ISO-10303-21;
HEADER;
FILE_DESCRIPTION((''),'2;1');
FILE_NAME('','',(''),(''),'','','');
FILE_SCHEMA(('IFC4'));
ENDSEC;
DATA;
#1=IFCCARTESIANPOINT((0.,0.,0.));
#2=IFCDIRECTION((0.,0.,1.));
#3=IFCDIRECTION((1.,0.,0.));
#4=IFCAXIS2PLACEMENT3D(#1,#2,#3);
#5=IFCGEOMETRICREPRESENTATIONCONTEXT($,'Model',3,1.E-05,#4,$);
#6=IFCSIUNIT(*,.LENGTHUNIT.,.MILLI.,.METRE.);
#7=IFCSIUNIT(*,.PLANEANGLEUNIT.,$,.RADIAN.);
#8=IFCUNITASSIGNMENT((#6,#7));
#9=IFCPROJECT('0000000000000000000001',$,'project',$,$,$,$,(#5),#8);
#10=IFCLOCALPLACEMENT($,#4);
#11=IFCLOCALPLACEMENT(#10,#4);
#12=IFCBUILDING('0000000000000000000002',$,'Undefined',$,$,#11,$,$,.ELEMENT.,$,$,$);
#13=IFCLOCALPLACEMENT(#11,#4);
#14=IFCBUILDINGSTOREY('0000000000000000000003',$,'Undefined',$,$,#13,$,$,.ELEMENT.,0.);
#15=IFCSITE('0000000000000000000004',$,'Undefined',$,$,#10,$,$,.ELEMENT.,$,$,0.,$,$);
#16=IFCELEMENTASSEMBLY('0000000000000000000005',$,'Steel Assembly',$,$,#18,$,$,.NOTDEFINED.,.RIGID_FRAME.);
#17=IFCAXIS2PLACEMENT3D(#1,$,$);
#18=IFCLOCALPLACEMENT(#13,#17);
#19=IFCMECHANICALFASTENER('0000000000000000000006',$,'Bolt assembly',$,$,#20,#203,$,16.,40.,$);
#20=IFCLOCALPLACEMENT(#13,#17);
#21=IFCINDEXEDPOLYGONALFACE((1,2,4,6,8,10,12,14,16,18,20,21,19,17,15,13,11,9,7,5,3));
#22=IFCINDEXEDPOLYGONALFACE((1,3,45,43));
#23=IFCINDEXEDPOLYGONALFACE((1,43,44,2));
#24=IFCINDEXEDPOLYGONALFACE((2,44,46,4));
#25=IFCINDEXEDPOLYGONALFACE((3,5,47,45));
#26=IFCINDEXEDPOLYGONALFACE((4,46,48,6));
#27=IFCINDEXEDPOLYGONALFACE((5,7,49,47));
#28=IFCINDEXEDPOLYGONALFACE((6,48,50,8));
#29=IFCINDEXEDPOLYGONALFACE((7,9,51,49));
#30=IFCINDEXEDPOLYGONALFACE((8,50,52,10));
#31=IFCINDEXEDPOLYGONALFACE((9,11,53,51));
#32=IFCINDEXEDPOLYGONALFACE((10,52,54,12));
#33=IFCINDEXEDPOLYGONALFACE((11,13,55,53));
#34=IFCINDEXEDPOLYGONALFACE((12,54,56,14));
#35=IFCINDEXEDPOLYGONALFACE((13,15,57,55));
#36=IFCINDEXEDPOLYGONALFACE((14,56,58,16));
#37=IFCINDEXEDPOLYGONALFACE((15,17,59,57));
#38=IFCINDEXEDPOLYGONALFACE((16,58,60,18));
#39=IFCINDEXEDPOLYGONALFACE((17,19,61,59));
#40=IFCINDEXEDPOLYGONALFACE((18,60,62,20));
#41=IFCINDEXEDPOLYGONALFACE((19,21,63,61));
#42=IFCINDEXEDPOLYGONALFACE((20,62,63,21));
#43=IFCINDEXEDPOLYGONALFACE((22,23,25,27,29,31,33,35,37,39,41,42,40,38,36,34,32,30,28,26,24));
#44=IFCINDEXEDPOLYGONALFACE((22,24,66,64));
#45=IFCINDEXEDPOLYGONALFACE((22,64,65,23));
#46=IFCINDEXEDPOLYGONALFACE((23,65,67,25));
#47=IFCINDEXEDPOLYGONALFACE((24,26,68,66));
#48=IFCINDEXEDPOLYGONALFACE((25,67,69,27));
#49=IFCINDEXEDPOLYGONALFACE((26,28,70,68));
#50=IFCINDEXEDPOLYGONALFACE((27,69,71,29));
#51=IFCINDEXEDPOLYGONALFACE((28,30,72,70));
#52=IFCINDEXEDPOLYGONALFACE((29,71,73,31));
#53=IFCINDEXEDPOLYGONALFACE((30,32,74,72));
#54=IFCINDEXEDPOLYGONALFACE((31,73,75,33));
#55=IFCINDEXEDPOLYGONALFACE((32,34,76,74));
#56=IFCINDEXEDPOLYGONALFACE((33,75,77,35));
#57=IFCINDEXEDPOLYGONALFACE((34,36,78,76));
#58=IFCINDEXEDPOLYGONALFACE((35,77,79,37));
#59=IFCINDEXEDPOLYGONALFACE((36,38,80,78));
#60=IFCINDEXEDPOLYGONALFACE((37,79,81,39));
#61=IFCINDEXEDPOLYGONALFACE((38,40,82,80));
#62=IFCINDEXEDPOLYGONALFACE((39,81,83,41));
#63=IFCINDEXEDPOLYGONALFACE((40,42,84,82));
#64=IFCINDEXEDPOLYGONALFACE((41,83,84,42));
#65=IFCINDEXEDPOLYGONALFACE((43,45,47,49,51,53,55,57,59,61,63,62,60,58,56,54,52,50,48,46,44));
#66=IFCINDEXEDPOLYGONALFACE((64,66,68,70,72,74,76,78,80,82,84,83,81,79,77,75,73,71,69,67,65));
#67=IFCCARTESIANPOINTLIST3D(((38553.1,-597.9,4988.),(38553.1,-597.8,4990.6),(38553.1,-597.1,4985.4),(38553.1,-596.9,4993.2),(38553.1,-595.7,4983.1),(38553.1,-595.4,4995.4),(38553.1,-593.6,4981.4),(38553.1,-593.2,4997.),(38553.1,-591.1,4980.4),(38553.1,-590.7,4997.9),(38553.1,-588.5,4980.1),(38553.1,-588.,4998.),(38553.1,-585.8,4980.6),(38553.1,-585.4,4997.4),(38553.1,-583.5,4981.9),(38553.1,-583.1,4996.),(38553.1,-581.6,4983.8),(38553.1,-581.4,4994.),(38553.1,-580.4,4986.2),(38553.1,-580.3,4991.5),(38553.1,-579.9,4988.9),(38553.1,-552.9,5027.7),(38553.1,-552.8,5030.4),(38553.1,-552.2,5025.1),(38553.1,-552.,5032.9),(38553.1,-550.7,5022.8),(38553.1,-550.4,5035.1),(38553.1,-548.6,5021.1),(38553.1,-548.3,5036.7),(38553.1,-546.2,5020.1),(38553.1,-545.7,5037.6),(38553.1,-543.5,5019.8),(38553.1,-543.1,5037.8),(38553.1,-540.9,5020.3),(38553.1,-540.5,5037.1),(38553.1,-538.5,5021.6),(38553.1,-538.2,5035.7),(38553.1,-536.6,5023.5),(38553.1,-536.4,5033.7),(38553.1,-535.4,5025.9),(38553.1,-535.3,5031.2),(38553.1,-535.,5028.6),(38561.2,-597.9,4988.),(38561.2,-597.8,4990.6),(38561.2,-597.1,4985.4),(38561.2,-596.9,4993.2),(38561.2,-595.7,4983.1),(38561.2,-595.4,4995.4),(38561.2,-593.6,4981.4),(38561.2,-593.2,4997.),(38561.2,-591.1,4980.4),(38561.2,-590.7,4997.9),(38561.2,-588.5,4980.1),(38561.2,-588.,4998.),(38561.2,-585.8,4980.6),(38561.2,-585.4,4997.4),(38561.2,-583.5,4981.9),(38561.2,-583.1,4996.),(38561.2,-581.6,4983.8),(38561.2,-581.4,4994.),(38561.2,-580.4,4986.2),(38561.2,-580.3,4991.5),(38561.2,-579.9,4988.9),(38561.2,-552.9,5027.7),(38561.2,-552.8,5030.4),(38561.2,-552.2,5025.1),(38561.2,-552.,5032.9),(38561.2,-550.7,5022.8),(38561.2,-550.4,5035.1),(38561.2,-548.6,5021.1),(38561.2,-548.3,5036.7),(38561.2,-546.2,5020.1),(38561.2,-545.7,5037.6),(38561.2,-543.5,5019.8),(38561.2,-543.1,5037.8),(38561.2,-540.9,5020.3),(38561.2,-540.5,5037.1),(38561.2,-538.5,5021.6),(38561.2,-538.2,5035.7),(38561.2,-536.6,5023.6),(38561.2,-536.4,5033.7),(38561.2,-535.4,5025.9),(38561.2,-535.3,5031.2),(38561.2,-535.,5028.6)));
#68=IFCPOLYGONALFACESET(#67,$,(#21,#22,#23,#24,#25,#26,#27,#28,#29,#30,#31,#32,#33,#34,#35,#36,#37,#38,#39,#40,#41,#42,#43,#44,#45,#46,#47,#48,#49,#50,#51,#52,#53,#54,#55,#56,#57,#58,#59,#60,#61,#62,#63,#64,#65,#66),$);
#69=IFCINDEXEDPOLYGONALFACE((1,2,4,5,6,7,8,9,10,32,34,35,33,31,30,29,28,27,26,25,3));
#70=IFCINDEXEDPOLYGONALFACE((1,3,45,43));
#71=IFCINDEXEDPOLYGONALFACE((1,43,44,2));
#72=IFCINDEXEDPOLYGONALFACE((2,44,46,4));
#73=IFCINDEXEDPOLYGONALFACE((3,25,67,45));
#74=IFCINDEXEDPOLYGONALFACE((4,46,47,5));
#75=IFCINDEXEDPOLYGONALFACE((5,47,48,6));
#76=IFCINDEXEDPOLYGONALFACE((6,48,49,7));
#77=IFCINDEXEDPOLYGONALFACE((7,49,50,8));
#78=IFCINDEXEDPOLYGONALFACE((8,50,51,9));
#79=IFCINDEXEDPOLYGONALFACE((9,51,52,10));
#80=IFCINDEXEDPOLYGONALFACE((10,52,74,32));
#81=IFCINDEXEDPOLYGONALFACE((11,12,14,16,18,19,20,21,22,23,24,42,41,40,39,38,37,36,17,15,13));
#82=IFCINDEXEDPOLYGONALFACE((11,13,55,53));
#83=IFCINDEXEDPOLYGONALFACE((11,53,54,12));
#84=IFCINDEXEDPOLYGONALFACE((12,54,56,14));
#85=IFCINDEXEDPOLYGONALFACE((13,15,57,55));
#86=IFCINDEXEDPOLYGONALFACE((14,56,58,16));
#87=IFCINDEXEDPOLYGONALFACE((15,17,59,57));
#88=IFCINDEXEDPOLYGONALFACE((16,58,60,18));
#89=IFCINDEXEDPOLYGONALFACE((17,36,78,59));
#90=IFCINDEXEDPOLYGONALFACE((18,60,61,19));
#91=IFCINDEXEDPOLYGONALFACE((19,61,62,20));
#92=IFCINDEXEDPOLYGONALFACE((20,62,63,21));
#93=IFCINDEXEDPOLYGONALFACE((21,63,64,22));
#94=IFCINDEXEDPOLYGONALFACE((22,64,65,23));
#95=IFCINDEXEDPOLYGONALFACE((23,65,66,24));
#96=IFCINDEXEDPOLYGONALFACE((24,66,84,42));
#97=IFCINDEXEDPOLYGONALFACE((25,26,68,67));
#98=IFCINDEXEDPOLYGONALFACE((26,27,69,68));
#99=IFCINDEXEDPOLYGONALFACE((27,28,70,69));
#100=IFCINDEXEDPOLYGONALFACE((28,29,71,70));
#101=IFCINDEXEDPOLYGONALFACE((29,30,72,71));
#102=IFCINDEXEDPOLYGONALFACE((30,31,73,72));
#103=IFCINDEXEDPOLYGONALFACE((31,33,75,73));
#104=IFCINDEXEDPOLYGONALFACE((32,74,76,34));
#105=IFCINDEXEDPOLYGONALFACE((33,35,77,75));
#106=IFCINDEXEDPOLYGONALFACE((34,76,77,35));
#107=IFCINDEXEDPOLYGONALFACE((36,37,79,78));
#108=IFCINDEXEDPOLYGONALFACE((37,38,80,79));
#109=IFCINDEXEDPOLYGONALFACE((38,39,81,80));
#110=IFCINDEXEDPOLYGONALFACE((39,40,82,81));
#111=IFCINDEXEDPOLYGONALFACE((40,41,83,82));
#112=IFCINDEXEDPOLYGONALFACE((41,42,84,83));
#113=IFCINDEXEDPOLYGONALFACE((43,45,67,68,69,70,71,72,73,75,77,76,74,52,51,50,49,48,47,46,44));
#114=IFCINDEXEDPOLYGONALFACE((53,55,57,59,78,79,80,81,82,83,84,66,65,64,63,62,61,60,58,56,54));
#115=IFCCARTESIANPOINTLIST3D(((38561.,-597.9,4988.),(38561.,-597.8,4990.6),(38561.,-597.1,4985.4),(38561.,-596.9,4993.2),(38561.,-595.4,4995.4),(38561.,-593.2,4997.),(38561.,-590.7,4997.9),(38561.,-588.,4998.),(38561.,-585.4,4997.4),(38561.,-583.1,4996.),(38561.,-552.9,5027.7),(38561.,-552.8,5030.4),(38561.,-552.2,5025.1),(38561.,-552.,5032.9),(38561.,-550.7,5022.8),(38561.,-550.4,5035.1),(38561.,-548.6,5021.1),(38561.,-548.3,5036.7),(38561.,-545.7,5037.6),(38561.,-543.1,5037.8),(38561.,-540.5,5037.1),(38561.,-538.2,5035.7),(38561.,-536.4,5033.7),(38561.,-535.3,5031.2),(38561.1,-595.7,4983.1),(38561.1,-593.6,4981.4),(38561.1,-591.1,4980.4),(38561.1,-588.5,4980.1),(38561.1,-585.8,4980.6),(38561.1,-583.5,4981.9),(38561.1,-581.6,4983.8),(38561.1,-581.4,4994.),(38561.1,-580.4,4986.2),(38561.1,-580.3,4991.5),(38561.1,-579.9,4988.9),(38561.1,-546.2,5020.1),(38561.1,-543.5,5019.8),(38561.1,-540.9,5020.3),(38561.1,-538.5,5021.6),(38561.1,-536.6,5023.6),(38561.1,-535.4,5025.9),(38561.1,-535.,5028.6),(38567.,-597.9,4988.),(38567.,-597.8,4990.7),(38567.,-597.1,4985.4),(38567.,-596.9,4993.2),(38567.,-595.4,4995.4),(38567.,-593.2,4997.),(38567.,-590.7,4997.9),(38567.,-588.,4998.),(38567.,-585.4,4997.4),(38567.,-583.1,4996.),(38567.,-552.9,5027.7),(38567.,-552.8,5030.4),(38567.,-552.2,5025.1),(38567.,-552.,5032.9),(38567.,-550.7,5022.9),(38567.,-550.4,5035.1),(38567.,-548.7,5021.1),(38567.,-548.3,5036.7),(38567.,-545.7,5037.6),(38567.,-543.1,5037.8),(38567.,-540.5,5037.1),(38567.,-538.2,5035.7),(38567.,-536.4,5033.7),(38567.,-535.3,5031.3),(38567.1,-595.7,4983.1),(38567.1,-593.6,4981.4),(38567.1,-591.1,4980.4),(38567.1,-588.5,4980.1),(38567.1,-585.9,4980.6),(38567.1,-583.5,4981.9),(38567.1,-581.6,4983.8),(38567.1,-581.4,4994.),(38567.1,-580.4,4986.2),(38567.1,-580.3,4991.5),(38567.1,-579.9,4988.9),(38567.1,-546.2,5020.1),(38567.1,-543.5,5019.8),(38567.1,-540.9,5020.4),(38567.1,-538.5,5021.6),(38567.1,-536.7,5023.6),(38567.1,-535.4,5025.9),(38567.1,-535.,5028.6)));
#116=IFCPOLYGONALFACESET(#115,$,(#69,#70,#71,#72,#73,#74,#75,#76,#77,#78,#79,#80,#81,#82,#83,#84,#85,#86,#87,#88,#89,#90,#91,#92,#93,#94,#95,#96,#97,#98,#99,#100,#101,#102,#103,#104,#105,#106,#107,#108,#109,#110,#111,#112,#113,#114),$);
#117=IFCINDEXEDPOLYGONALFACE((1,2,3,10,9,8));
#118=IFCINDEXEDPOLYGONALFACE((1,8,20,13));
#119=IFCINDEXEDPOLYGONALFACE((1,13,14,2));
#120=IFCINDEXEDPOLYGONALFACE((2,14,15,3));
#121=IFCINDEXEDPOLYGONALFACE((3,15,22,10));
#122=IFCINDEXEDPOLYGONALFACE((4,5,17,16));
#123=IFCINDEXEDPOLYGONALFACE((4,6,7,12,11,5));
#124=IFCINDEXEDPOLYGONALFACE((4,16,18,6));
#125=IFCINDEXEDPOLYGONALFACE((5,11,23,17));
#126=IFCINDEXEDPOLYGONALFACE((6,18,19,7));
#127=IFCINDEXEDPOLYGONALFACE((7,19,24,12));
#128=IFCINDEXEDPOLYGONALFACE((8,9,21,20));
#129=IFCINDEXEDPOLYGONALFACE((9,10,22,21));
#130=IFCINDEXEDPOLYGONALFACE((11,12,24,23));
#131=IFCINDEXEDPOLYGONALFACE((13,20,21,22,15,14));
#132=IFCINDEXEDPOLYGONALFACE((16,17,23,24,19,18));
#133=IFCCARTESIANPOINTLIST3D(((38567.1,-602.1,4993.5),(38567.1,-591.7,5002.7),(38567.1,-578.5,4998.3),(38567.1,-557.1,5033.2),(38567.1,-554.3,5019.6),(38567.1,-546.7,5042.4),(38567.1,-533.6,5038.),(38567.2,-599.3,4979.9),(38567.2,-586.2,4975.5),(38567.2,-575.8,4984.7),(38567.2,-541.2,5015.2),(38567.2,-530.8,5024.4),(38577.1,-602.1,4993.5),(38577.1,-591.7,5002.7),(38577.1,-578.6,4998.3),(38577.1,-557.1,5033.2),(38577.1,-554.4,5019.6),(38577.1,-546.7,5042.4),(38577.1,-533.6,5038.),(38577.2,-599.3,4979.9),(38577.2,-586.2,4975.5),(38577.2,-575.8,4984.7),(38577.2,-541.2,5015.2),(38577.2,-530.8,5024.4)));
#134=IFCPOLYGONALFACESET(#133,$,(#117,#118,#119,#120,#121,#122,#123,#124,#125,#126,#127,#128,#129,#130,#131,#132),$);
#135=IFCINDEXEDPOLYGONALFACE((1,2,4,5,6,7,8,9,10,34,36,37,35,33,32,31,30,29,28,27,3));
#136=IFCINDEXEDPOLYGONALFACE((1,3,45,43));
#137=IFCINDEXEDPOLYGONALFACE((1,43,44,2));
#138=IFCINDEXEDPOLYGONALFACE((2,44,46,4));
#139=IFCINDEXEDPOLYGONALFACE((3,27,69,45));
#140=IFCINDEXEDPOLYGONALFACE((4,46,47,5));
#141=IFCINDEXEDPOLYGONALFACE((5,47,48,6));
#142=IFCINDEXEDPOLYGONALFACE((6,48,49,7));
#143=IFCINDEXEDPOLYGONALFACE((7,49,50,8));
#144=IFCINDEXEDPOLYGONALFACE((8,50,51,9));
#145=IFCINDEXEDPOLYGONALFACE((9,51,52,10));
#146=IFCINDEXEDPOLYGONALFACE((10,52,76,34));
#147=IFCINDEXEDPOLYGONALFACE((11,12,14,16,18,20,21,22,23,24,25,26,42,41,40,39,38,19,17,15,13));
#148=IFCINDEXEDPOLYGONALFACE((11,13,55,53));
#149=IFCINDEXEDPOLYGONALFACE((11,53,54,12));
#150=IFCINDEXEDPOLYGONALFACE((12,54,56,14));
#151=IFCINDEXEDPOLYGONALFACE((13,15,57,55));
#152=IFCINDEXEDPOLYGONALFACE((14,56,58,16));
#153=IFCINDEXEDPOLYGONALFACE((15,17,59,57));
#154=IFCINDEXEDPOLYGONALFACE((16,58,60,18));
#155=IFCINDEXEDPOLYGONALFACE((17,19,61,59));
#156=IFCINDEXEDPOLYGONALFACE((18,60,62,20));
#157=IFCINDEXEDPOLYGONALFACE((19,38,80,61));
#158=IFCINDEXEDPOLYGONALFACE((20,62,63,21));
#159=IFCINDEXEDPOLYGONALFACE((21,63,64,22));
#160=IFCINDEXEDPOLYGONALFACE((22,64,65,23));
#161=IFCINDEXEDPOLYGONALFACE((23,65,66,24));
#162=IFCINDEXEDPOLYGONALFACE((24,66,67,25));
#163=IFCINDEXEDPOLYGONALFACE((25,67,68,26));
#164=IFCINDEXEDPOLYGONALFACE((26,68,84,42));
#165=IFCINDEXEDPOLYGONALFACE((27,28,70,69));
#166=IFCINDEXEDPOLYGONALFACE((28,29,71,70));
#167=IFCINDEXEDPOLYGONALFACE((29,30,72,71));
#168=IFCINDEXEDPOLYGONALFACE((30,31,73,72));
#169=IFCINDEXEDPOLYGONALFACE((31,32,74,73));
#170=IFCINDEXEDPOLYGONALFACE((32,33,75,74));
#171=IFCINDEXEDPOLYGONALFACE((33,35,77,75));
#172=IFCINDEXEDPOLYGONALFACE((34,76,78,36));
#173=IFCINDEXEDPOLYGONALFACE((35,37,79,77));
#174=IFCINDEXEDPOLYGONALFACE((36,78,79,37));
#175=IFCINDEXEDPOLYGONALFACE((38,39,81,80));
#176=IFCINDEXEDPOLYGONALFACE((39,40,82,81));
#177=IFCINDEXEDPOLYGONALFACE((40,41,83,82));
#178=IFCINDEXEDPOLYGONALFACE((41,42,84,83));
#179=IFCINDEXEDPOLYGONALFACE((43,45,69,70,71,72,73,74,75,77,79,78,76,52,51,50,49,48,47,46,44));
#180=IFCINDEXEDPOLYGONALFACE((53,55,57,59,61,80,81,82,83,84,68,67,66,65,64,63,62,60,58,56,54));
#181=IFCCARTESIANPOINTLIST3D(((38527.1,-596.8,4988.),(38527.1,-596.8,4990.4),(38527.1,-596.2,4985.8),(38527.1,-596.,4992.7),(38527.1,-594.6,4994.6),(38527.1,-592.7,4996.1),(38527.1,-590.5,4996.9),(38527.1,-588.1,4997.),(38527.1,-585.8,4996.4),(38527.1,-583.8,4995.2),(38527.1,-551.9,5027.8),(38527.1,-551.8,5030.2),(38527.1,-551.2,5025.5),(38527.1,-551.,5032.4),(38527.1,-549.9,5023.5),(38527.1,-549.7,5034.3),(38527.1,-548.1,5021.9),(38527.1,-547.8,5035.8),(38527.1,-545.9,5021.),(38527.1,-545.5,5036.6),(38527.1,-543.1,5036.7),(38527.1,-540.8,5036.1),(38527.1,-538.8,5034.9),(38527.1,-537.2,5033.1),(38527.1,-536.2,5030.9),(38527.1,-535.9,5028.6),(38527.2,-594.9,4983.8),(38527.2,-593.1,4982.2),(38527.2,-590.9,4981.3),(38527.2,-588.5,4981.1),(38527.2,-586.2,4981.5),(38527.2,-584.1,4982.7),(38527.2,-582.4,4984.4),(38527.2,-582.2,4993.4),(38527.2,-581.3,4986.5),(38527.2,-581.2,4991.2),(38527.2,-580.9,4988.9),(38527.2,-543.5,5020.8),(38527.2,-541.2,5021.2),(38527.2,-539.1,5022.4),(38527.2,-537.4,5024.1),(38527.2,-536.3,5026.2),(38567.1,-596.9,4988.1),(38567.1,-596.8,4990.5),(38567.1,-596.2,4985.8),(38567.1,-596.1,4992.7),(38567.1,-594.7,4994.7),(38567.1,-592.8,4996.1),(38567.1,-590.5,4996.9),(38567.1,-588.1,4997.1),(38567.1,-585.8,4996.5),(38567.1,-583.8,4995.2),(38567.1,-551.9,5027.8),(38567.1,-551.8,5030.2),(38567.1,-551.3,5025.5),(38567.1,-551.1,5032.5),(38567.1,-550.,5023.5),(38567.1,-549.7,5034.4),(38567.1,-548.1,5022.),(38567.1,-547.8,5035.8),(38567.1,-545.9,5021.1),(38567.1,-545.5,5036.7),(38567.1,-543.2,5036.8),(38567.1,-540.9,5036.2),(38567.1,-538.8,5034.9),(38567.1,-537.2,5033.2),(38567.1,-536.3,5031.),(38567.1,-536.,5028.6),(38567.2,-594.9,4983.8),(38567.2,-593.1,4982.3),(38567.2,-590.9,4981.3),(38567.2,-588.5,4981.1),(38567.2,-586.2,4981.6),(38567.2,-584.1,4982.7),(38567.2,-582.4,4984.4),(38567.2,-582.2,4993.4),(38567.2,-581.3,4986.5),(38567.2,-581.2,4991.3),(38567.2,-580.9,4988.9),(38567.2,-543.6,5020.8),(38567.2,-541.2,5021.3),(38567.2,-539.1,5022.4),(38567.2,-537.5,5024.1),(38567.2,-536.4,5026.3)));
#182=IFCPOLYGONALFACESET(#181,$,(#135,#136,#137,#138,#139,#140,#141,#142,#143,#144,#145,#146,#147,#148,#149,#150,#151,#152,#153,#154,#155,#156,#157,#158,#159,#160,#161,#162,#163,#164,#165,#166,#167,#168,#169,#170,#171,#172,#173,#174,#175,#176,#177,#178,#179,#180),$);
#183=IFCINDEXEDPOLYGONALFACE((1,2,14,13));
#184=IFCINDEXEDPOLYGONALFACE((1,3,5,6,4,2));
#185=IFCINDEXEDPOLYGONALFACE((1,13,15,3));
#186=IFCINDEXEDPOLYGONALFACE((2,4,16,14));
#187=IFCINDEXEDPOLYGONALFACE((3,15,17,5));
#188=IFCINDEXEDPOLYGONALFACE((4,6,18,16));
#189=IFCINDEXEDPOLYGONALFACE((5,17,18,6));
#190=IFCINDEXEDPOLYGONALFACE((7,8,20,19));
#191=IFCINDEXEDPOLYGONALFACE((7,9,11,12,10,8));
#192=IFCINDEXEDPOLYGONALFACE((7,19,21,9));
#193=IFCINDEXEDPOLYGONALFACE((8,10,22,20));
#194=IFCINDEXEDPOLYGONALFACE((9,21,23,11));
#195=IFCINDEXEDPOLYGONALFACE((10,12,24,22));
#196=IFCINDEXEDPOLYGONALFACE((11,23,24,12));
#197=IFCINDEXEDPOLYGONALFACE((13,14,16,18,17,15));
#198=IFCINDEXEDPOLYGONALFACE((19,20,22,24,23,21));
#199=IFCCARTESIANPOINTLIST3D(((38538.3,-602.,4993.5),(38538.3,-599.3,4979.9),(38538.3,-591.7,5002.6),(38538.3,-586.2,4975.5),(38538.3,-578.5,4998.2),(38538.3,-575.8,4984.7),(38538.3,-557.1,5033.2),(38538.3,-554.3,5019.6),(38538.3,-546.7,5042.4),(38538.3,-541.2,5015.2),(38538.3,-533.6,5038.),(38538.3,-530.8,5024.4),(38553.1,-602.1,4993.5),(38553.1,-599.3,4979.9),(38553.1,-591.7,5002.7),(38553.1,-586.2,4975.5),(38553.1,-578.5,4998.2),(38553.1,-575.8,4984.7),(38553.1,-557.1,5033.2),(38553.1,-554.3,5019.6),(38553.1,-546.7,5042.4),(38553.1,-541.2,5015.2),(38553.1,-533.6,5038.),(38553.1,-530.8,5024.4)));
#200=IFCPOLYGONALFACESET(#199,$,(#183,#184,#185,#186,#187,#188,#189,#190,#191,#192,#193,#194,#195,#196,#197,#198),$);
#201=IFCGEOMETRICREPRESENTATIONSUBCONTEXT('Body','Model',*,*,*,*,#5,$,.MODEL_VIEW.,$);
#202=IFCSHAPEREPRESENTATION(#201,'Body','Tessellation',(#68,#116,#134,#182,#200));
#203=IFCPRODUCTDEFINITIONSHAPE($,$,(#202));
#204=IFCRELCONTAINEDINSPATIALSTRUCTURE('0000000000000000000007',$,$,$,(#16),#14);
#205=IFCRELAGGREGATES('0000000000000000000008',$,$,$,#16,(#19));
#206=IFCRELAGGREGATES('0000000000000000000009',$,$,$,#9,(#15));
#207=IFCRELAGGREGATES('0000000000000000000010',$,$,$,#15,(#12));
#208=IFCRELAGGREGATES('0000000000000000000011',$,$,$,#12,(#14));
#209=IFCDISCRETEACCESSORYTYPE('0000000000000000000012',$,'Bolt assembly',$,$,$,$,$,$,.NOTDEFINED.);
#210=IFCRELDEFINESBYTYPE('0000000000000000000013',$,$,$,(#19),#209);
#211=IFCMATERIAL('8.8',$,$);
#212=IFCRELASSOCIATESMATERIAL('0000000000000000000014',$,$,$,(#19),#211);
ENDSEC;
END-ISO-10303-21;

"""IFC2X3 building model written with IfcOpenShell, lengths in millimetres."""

from ifc_helpers import new_model, si_unit, frame, origin_with_axes, origin_2d_with_axis, place, context, subcontext, project, spatial, polyline, circle, outline, extrude, source, transform, mapped, material, type_object, element, aggregate, save


model = new_model("IFC2X3")

# Units and contexts
model_context = context("Model", 3, precision=1e-05, world=origin_with_axes())
body_context = subcontext(model_context, "Body", "Model", "MODEL_VIEW")
ifc_project = project(units=[si_unit("LENGTHUNIT", "METRE", prefix="MILLI"), si_unit("PLANEANGLEUNIT", "RADIAN")], contexts=[model_context])

# Site, building, storey
site_placement = place(None, origin_with_axes())
site = spatial("IfcSite", under=ifc_project, at=site_placement, Name="Undefined", CompositionType="ELEMENT", RefElevation=0.0)
building_placement = place(site_placement, origin_with_axes())
building = spatial("IfcBuilding", under=site, at=building_placement, Name="Undefined", CompositionType="ELEMENT")
storey_placement = place(building_placement, origin_with_axes())
storey = spatial("IfcBuildingStorey", under=building, at=storey_placement, Name="Undefined", CompositionType="ELEMENT", Elevation=0.0)

# Shared definitions
discrete_accessory_type_1 = type_object("IfcDiscreteAccessoryType", Name="Bolt assembly")

# Shared definitions
ifc_material_1 = material(Name="8.8")

# Element assembly, mechanical fastener
assembly_1_placement = place(storey_placement, origin_with_axes())
assembly_1 = element("IfcElementAssembly", 1, at=assembly_1_placement, inside=storey, Name="Steel Assembly", AssemblyPlace="NOTDEFINED", PredefinedType="RIGID_FRAME")
shared_shape_1 = source(origin_with_axes(), body_context, "Body", "SweptSolid", [
    extrude(circle(Radius=9.0, at=origin_2d_with_axis()), frame((0.0, -0.1, 0.0), z_axis=(0.0, 1.0, 0.0), x_axis=(1.0, 0.0, 0.0)), (0.0, 0.0, 1.0), 8.1),
    extrude(circle(Radius=9.0, at=origin_2d_with_axis()), frame((0.0, -5.9, 0.0), z_axis=(0.0, 1.0, 0.0), x_axis=(1.0, 0.0, 0.0)), (0.0, 0.0, 1.0), 6.0),
    extrude(outline(polyline([(13.9, 0.0), (6.9, 12.0), (-6.9, 12.0), (-13.9, 0.0), (-6.9, -12.0), (6.9, -12.0), (13.9, 0.0)])), frame((0.0, -16.0, 0.0), z_axis=(0.0, 1.0, 0.0), x_axis=(1.0, 0.0, 0.0)), (0.0, 0.0, 1.0), 10.0),
    extrude(circle(Radius=8.0, at=origin_2d_with_axis()), frame((0.0, -6.0, 0.0), z_axis=(0.0, 1.0, 0.0), x_axis=(1.0, 0.0, 0.0)), (0.0, 0.0, 1.0), 40.0),
    extrude(outline(polyline([(13.9, 0.0), (6.9, 12.0), (-6.9, 12.0), (-13.9, 0.0), (-6.9, -12.0), (6.9, -12.0), (13.9, 0.0)])), frame((0.0, 8.0, 0.0), z_axis=(0.0, 1.0, 0.0), x_axis=(1.0, 0.0, 0.0)), (0.0, 0.0, 1.0), 14.8),
])
mechanical_fastener_1_placement = place(assembly_1_placement, frame((38561.1, -564.5, 5052.0), z_axis=(0.001393, 0.661976, -0.749524), x_axis=(0.000116, -0.749525, -0.661976)))
mechanical_fastener_1 = element("IfcMechanicalFastener", 2, at=mechanical_fastener_1_placement, type_object=discrete_accessory_type_1, material=ifc_material_1, Name="Bolt assembly", NominalDiameter=16.0, NominalLength=40.0, context=body_context, shape_type="MappedRepresentation", body=[
    mapped(shared_shape_1, transform((0.0, 0.0, 31.0))),
    mapped(shared_shape_1, transform((60.0, 0.0, 31.0))),
])
aggregate(assembly_1, [mechanical_fastener_1])

save(model, "model.ifc")
